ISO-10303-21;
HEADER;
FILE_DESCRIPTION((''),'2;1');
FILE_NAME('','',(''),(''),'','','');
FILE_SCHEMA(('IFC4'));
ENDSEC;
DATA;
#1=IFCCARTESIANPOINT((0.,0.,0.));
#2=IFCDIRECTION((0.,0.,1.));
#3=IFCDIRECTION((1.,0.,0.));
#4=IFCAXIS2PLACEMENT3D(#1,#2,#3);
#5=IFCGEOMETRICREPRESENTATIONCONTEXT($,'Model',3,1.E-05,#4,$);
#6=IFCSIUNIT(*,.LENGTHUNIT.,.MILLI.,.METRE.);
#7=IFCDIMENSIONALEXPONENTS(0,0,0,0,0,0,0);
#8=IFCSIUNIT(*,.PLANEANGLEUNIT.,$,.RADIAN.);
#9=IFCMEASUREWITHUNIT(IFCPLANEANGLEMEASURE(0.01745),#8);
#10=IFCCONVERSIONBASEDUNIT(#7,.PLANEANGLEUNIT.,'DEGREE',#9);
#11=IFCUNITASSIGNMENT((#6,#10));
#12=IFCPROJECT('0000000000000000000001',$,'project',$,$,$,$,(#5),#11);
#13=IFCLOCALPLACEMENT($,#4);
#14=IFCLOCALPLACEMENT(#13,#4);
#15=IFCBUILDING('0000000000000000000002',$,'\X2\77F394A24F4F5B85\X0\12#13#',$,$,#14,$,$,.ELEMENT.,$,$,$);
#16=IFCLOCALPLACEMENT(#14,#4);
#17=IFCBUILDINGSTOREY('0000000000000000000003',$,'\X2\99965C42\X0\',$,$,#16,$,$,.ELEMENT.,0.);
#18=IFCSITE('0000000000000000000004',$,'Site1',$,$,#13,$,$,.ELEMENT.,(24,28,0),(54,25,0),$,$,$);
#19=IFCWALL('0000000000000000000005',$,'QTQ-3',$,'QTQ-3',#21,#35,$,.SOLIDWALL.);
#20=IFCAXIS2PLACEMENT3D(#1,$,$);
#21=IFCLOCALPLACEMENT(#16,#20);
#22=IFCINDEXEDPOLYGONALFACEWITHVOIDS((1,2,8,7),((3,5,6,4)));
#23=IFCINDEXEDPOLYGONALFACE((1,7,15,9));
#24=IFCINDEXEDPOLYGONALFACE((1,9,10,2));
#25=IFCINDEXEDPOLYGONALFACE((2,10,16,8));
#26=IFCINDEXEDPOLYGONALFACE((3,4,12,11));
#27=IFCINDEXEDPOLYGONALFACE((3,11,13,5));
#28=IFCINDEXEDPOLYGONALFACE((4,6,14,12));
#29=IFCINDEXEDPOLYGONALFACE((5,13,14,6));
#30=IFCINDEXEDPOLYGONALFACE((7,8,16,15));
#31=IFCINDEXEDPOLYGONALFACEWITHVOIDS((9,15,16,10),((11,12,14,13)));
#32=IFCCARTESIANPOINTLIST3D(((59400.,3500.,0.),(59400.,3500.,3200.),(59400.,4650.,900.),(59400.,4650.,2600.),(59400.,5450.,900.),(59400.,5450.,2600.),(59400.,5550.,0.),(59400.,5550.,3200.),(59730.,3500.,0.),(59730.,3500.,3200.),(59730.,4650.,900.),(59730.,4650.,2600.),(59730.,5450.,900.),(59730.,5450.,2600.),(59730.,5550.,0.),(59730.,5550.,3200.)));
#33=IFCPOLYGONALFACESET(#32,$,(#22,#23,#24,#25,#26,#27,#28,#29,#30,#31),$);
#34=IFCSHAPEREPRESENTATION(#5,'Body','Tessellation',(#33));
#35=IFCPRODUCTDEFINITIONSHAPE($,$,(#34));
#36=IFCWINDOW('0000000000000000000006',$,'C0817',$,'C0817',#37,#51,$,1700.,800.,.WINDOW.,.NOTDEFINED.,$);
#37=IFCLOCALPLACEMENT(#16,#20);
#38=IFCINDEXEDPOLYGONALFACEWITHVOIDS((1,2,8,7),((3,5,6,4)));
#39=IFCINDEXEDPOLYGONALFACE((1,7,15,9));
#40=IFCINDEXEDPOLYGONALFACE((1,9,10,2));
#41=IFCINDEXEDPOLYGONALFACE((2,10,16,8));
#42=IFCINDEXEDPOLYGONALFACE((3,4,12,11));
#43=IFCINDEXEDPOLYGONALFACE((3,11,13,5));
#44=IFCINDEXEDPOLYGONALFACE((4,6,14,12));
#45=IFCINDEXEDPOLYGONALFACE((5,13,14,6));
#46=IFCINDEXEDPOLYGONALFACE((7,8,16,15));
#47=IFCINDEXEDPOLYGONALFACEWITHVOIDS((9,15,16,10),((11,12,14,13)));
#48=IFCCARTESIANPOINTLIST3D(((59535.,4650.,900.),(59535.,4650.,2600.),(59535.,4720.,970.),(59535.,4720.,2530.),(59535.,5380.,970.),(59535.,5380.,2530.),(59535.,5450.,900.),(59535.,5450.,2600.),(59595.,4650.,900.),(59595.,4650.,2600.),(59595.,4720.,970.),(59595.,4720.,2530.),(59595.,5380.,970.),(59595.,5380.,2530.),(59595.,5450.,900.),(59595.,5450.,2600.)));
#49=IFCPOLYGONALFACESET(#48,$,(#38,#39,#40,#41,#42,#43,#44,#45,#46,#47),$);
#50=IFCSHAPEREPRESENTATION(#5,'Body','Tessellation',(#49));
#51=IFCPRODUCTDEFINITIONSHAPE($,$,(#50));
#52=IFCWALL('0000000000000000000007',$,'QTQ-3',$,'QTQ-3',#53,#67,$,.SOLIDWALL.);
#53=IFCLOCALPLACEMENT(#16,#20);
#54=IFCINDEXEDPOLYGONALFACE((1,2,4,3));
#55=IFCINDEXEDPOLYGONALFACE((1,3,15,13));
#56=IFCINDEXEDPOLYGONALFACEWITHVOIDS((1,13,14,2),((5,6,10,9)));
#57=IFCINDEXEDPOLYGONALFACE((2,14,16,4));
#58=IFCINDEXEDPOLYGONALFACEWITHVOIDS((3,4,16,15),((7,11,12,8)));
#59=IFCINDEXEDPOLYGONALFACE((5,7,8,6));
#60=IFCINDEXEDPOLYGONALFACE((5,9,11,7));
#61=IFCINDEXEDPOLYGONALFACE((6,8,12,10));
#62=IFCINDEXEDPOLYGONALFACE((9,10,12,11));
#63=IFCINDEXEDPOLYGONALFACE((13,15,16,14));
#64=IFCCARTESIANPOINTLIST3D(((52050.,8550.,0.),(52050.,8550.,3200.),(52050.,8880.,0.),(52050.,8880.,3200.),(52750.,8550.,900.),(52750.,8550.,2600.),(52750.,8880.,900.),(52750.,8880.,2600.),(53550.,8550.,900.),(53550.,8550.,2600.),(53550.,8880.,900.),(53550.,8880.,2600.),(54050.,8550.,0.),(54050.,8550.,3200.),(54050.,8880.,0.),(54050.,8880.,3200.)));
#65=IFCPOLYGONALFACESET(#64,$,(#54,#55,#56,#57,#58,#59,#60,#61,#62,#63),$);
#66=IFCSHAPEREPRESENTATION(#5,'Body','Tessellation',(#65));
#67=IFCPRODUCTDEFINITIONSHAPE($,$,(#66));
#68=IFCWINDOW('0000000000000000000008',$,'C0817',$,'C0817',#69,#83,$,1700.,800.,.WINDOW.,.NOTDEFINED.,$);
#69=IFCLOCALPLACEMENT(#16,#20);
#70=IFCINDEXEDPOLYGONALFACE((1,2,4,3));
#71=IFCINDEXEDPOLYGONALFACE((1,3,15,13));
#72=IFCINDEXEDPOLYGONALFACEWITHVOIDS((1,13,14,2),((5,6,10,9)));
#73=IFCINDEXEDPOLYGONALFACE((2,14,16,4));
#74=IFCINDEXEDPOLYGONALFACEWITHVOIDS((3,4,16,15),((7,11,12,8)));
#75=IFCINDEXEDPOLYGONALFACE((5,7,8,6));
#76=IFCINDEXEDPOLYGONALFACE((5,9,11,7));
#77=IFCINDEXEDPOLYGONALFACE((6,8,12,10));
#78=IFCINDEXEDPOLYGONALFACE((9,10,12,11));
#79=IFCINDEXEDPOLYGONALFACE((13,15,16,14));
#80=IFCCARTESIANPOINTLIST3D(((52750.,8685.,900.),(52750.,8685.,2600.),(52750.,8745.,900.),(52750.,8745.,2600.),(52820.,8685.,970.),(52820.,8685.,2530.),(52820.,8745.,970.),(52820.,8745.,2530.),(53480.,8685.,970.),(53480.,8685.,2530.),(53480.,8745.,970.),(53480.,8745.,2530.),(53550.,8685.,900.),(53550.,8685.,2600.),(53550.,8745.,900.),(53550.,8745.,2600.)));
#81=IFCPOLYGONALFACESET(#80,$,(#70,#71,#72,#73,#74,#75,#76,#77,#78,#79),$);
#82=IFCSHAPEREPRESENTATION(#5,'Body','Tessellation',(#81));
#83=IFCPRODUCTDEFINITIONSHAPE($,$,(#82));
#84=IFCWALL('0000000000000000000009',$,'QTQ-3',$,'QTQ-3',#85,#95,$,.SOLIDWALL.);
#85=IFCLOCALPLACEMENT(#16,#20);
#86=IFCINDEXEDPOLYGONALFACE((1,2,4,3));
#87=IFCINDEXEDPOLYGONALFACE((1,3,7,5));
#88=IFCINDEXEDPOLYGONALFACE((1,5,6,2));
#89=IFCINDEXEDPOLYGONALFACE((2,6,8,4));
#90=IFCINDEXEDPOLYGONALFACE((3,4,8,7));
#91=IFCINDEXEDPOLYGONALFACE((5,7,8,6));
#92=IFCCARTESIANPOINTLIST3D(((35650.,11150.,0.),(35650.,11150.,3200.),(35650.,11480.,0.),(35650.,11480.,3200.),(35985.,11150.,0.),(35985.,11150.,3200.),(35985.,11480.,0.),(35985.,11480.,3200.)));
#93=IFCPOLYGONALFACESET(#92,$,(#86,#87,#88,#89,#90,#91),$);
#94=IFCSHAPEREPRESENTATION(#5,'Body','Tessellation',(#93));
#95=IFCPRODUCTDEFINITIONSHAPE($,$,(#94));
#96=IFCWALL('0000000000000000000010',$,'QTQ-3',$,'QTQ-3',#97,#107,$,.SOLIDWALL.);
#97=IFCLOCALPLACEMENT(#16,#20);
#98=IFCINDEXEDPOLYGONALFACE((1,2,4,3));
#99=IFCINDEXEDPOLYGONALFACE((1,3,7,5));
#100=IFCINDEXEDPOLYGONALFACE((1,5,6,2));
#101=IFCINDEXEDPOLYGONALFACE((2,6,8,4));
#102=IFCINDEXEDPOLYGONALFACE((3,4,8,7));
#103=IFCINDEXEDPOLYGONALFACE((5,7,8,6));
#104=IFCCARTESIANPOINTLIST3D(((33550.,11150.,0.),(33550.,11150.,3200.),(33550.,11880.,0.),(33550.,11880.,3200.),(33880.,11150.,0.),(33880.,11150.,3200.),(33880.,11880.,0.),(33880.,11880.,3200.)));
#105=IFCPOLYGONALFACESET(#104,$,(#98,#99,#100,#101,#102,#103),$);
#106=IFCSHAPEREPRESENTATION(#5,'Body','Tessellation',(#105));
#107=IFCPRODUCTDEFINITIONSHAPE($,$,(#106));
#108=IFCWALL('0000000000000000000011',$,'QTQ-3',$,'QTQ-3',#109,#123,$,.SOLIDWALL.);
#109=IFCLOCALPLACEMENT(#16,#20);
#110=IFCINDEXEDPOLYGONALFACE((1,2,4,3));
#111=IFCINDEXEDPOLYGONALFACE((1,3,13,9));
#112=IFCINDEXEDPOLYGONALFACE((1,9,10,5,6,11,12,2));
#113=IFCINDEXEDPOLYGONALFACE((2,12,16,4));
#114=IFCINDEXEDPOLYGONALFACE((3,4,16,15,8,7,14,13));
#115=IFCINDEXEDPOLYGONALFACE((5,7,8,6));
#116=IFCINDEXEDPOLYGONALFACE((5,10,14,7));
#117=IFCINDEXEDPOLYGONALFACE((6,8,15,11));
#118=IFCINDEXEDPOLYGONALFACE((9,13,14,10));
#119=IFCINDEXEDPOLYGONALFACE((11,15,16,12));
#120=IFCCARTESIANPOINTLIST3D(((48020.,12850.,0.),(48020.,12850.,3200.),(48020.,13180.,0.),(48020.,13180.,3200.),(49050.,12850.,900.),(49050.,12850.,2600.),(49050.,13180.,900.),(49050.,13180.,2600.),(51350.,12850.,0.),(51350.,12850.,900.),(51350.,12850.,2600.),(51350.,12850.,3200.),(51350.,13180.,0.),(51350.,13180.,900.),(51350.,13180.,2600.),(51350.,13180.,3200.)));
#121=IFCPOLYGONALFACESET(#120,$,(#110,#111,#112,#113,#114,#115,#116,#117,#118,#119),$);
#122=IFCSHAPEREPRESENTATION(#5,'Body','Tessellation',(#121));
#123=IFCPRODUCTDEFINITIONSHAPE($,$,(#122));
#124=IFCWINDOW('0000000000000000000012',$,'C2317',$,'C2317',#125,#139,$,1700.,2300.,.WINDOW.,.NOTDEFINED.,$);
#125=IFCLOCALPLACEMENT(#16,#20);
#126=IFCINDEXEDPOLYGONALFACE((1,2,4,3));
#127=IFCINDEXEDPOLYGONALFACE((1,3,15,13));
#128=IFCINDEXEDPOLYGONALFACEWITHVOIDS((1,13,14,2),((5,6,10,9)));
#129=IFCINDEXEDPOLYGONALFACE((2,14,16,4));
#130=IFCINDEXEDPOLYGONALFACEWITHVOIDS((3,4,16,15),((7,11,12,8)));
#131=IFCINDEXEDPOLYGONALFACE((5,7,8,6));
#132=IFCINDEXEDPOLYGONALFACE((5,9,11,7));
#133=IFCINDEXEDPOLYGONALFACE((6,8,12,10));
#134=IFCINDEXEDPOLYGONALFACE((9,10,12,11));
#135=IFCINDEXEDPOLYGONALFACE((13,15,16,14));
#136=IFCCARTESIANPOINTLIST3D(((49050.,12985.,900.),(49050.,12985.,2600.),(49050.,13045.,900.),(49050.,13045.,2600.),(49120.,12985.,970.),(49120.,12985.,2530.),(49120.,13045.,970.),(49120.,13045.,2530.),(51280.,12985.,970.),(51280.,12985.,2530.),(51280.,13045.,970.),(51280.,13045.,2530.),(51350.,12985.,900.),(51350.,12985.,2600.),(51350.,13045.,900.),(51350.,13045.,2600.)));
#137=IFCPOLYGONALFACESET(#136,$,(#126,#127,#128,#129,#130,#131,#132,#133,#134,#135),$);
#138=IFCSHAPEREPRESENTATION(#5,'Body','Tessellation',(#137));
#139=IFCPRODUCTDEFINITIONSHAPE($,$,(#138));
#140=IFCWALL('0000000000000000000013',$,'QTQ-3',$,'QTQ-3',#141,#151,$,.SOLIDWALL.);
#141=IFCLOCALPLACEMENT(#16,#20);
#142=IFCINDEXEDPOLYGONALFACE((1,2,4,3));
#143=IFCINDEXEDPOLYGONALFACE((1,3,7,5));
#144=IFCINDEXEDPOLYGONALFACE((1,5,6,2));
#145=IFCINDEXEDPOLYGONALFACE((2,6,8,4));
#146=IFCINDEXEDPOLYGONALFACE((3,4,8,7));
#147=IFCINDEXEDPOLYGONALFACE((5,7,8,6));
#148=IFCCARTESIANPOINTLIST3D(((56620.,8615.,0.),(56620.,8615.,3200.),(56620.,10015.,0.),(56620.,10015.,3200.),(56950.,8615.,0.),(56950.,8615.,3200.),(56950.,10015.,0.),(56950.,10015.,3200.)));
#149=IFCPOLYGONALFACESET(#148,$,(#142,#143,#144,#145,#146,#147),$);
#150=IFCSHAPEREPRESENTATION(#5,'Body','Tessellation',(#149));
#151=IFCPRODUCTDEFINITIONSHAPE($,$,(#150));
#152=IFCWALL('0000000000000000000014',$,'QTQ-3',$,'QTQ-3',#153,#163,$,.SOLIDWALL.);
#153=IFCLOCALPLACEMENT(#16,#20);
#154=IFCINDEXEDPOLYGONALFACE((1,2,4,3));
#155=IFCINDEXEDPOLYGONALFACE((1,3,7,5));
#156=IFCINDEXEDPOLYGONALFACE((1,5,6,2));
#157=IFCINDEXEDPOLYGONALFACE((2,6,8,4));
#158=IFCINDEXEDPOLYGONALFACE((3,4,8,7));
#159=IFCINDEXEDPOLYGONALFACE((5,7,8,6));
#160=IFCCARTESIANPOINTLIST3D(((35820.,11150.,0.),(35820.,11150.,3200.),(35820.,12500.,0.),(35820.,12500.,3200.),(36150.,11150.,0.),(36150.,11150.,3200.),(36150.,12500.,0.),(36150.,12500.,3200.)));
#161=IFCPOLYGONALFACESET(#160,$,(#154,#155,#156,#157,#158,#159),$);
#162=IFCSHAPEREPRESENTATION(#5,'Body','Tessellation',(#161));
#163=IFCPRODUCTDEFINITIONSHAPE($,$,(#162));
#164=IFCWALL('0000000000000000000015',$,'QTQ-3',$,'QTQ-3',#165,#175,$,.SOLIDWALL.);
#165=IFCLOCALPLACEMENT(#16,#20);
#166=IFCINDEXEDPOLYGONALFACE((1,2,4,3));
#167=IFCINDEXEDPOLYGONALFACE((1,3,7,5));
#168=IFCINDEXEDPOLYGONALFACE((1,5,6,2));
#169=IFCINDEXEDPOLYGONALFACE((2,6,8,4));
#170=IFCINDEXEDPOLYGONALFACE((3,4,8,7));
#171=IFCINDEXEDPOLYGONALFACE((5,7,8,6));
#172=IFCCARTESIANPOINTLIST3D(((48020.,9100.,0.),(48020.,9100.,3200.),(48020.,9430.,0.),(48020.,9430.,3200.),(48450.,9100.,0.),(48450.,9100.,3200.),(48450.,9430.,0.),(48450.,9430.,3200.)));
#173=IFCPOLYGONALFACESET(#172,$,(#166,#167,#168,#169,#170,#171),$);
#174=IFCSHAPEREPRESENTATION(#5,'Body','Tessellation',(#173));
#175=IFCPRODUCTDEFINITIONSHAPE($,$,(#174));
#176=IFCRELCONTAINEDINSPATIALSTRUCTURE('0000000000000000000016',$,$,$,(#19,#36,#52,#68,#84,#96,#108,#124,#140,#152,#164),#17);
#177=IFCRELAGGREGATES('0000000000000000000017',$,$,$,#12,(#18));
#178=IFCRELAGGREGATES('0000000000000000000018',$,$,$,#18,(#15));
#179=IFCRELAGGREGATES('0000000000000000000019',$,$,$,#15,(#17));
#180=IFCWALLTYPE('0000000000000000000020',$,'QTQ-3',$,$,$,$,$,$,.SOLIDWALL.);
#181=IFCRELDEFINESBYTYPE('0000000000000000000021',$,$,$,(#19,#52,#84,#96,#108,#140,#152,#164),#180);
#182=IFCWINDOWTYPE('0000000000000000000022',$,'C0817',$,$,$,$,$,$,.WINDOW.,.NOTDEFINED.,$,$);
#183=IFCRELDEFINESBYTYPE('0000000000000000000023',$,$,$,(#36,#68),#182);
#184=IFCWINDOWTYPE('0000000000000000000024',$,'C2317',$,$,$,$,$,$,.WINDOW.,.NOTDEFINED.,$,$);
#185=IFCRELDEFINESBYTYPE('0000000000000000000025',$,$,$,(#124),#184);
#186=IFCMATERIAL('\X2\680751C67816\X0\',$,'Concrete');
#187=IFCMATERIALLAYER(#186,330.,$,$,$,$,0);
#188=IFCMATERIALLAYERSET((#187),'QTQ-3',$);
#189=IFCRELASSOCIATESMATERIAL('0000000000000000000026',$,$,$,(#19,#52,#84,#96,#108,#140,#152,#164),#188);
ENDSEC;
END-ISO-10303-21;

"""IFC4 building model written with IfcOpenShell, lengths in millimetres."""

from ifc_helpers import new_model, entity, si_unit, converted_unit, frame, origin_with_axes, place, context, project, spatial, polyline, outline, extrude, material, layer, layer_set, type_object, element, fill, save


model = new_model("IFC4")

# Units and contexts
model_context = context("Model", 3, precision=1e-05, world=origin_with_axes())
ifc_project = project(units=[si_unit("LENGTHUNIT", "METRE", prefix="MILLI"), converted_unit("PLANEANGLEUNIT", "DEGREE", entity("IfcPlaneAngleMeasure", 0.01745), si_unit("PLANEANGLEUNIT", "RADIAN"), dimensions=[0, 0, 0, 0, 0, 0, 0])], contexts=[model_context])

# Site, building, storey
site_placement = place(None, origin_with_axes())
site = spatial("IfcSite", under=ifc_project, at=site_placement, Name="Site1", CompositionType="ELEMENT", RefLatitude=(24, 28, 0), RefLongitude=(54, 25, 0))
building_placement = place(site_placement, origin_with_axes())
building = spatial("IfcBuilding", under=site, at=building_placement, Name="石钢住宅12#13#", CompositionType="ELEMENT")
storey_placement = place(building_placement, origin_with_axes())
storey = spatial("IfcBuildingStorey", under=building, at=storey_placement, Name="首层", CompositionType="ELEMENT", Elevation=0.0)

# Walls, openings, windows
ifc_material_1 = material(Name="标准砖", Category="Concrete")
ifc_layer_1 = layer(ifc_material_1, 330.0, Priority=0)
ifc_layer_set_1 = layer_set([ifc_layer_1], Name="QTQ-3")
wall_type_1 = type_object("IfcWallType", Name="QTQ-3", PredefinedType="SOLIDWALL")
wall_1_placement = place(storey_placement, origin_with_axes())
wall_1 = element("IfcWall", 1, at=wall_1_placement, inside=storey, type_object=wall_type_1, material=ifc_layer_set_1, Name="QTQ-3", ObjectType="QTQ-3", PredefinedType="SOLIDWALL", context=model_context, shape_type="SweptSolid", body=[
    extrude(outline(polyline([(0.0, 0.0), (3200.0, 0.0), (3200.0, 2050.0), (0.0, 2050.0), (0.0, 0.0)])), frame((59730.0, 5550.0, 3200.0), z_axis=(-1.0, 0.0, 0.0), x_axis=(0.0, 0.0, -1.0)), (0.0, 0.0, 1.0), 330.0),
])
opening_1_placement = place(storey_placement, origin_with_axes())
opening_1 = element("IfcOpeningElement", 2, at=opening_1_placement, cuts=wall_1, PredefinedType="OPENING", context=model_context, shape_type="SweptSolid", body=[
    extrude(outline(polyline([(0.0, 0.0), (800.0, 0.0), (800.0, 1700.0), (0.0, 1700.0), (0.0, 0.0)])), frame((60730.0, 5450.0, 900.0), z_axis=(-1.0, 0.0, 0.0), x_axis=(0.0, -1.0, 0.0)), (0.0, 0.0, 1.0), 2330.0),
])
window_type_1 = type_object("IfcWindowType", Name="C0817", PartitioningType="NOTDEFINED", PredefinedType="WINDOW")
window_1_placement = place(storey_placement, origin_with_axes())
window_1 = element("IfcWindow", 3, at=window_1_placement, inside=storey, type_object=window_type_1, Name="C0817", ObjectType="C0817", OverallHeight=1700.0, OverallWidth=800.0, PartitioningType="NOTDEFINED", PredefinedType="WINDOW", context=model_context, shape_type="SweptSolid", body=[
    extrude(outline(polyline([(-400.0, -850.0), (400.0, -850.0), (400.0, 850.0), (-400.0, 850.0), (-400.0, -850.0)]), holes=[polyline([(-330.0, -780.0), (-330.0, 780.0), (330.0, 780.0), (330.0, -780.0), (-330.0, -780.0)])]), frame((59595.0, 5050.0, 1750.0), z_axis=(-1.0, 0.0, 0.0), x_axis=(0.0, -1.0, 0.0)), (0.0, 0.0, 1.0), 60.0),
])
fill(opening_1, window_1)
wall_2_placement = place(storey_placement, origin_with_axes())
wall_2 = element("IfcWall", 4, at=wall_2_placement, inside=storey, type_object=wall_type_1, material=ifc_layer_set_1, Name="QTQ-3", ObjectType="QTQ-3", PredefinedType="SOLIDWALL", context=model_context, shape_type="SweptSolid", body=[
    extrude(outline(polyline([(0.0, 0.0), (3200.0, 0.0), (3200.0, 2000.0), (0.0, 2000.0), (0.0, 0.0)])), frame((54050.0, 8550.0, 3200.0), z_axis=(0.0, 1.0, 0.0), x_axis=(0.0, 0.0, -1.0)), (0.0, 0.0, 1.0), 330.0),
])
opening_2_placement = place(storey_placement, origin_with_axes())
opening_2 = element("IfcOpeningElement", 5, at=opening_2_placement, cuts=wall_2, PredefinedType="OPENING", context=model_context, shape_type="SweptSolid", body=[
    extrude(outline(polyline([(0.0, 0.0), (800.0, 0.0), (800.0, 1700.0), (0.0, 1700.0), (0.0, 0.0)])), frame((53550.0, 7550.0, 900.0), z_axis=(0.0, 1.0, 0.0), x_axis=(-1.0, 0.0, 0.0)), (0.0, 0.0, 1.0), 2330.0),
])
window_2_placement = place(storey_placement, origin_with_axes())
window_2 = element("IfcWindow", 6, at=window_2_placement, inside=storey, type_object=window_type_1, Name="C0817", ObjectType="C0817", OverallHeight=1700.0, OverallWidth=800.0, PartitioningType="NOTDEFINED", PredefinedType="WINDOW", context=model_context, shape_type="SweptSolid", body=[
    extrude(outline(polyline([(-400.0, -850.0), (400.0, -850.0), (400.0, 850.0), (-400.0, 850.0), (-400.0, -850.0)]), holes=[polyline([(-330.0, -780.0), (-330.0, 780.0), (330.0, 780.0), (330.0, -780.0), (-330.0, -780.0)])]), frame((53150.0, 8685.0, 1750.0), z_axis=(0.0, 1.0, 0.0), x_axis=(-1.0, 0.0, 0.0)), (0.0, 0.0, 1.0), 60.0),
])
fill(opening_2, window_2)

# Walls
wall_3_placement = place(storey_placement, origin_with_axes())
element("IfcWall", 7, at=wall_3_placement, inside=storey, type_object=wall_type_1, material=ifc_layer_set_1, Name="QTQ-3", ObjectType="QTQ-3", PredefinedType="SOLIDWALL", context=model_context, shape_type="SweptSolid", body=[
    extrude(outline(polyline([(0.0, 0.0), (3200.0, 0.0), (3200.0, 335.0), (0.0, 335.0), (0.0, 0.0)])), frame((35985.0, 11150.0, 3200.0), z_axis=(0.0, 1.0, 0.0), x_axis=(0.0, 0.0, -1.0)), (0.0, 0.0, 1.0), 330.0),
])
wall_4_placement = place(storey_placement, origin_with_axes())
element("IfcWall", 8, at=wall_4_placement, inside=storey, type_object=wall_type_1, material=ifc_layer_set_1, Name="QTQ-3", ObjectType="QTQ-3", PredefinedType="SOLIDWALL", context=model_context, shape_type="SweptSolid", body=[
    extrude(outline(polyline([(0.0, 0.0), (3200.0, 0.0), (3200.0, 730.0), (0.0, 730.0), (0.0, 0.0)])), frame((33880.0, 11880.0, 3200.0), z_axis=(-1.0, 0.0, 0.0), x_axis=(0.0, 0.0, -1.0)), (0.0, 0.0, 1.0), 330.0),
])

# Wall, opening, window
wall_5_placement = place(storey_placement, origin_with_axes())
wall_5 = element("IfcWall", 9, at=wall_5_placement, inside=storey, type_object=wall_type_1, material=ifc_layer_set_1, Name="QTQ-3", ObjectType="QTQ-3", PredefinedType="SOLIDWALL", context=model_context, shape_type="SweptSolid", body=[
    extrude(outline(polyline([(0.0, 0.0), (3200.0, 0.0), (3200.0, 3330.0), (0.0, 3330.0), (0.0, 0.0)])), frame((51350.0, 12850.0, 3200.0), z_axis=(0.0, 1.0, 0.0), x_axis=(0.0, 0.0, -1.0)), (0.0, 0.0, 1.0), 330.0),
])
opening_3_placement = place(storey_placement, origin_with_axes())
opening_3 = element("IfcOpeningElement", 10, at=opening_3_placement, cuts=wall_5, PredefinedType="OPENING", context=model_context, shape_type="SweptSolid", body=[
    extrude(outline(polyline([(0.0, 0.0), (2300.0, 0.0), (2300.0, 1700.0), (0.0, 1700.0), (0.0, 0.0)])), frame((51350.0, 11850.0, 900.0), z_axis=(0.0, 1.0, 0.0), x_axis=(-1.0, 0.0, 0.0)), (0.0, 0.0, 1.0), 2330.0),
])
window_type_2 = type_object("IfcWindowType", Name="C2317", PartitioningType="NOTDEFINED", PredefinedType="WINDOW")
window_3_placement = place(storey_placement, origin_with_axes())
window_3 = element("IfcWindow", 11, at=window_3_placement, inside=storey, type_object=window_type_2, Name="C2317", ObjectType="C2317", OverallHeight=1700.0, OverallWidth=2300.0, PartitioningType="NOTDEFINED", PredefinedType="WINDOW", context=model_context, shape_type="SweptSolid", body=[
    extrude(outline(polyline([(-1150.0, -850.0), (1150.0, -850.0), (1150.0, 850.0), (-1150.0, 850.0), (-1150.0, -850.0)]), holes=[polyline([(-1080.0, -780.0), (-1080.0, 780.0), (1080.0, 780.0), (1080.0, -780.0), (-1080.0, -780.0)])]), frame((50200.0, 12985.0, 1750.0), z_axis=(0.0, 1.0, 0.0), x_axis=(-1.0, 0.0, 0.0)), (0.0, 0.0, 1.0), 60.0),
])
fill(opening_3, window_3)

# Walls
wall_6_placement = place(storey_placement, origin_with_axes())
element("IfcWall", 12, at=wall_6_placement, inside=storey, type_object=wall_type_1, material=ifc_layer_set_1, Name="QTQ-3", ObjectType="QTQ-3", PredefinedType="SOLIDWALL", context=model_context, shape_type="SweptSolid", body=[
    extrude(outline(polyline([(0.0, 0.0), (3200.0, 0.0), (3200.0, 1400.0), (0.0, 1400.0), (0.0, 0.0)])), frame((56950.0, 10015.0, 3200.0), z_axis=(-1.0, 0.0, 0.0), x_axis=(0.0, 0.0, -1.0)), (0.0, 0.0, 1.0), 330.0),
])
wall_7_placement = place(storey_placement, origin_with_axes())
element("IfcWall", 13, at=wall_7_placement, inside=storey, type_object=wall_type_1, material=ifc_layer_set_1, Name="QTQ-3", ObjectType="QTQ-3", PredefinedType="SOLIDWALL", context=model_context, shape_type="SweptSolid", body=[
    extrude(outline(polyline([(0.0, 0.0), (3200.0, 0.0), (3200.0, 1350.0), (0.0, 1350.0), (0.0, 0.0)])), frame((36150.0, 12500.0, 3200.0), z_axis=(-1.0, 0.0, 0.0), x_axis=(0.0, 0.0, -1.0)), (0.0, 0.0, 1.0), 330.0),
])
wall_8_placement = place(storey_placement, origin_with_axes())
element("IfcWall", 14, at=wall_8_placement, inside=storey, type_object=wall_type_1, material=ifc_layer_set_1, Name="QTQ-3", ObjectType="QTQ-3", PredefinedType="SOLIDWALL", context=model_context, shape_type="SweptSolid", body=[
    extrude(outline(polyline([(0.0, 0.0), (3200.0, 0.0), (3200.0, 430.0), (0.0, 430.0), (0.0, 0.0)])), frame((48450.0, 9100.0, 3200.0), z_axis=(0.0, 1.0, 0.0), x_axis=(0.0, 0.0, -1.0)), (0.0, 0.0, 1.0), 330.0),
])

save(model, "model.ifc")
